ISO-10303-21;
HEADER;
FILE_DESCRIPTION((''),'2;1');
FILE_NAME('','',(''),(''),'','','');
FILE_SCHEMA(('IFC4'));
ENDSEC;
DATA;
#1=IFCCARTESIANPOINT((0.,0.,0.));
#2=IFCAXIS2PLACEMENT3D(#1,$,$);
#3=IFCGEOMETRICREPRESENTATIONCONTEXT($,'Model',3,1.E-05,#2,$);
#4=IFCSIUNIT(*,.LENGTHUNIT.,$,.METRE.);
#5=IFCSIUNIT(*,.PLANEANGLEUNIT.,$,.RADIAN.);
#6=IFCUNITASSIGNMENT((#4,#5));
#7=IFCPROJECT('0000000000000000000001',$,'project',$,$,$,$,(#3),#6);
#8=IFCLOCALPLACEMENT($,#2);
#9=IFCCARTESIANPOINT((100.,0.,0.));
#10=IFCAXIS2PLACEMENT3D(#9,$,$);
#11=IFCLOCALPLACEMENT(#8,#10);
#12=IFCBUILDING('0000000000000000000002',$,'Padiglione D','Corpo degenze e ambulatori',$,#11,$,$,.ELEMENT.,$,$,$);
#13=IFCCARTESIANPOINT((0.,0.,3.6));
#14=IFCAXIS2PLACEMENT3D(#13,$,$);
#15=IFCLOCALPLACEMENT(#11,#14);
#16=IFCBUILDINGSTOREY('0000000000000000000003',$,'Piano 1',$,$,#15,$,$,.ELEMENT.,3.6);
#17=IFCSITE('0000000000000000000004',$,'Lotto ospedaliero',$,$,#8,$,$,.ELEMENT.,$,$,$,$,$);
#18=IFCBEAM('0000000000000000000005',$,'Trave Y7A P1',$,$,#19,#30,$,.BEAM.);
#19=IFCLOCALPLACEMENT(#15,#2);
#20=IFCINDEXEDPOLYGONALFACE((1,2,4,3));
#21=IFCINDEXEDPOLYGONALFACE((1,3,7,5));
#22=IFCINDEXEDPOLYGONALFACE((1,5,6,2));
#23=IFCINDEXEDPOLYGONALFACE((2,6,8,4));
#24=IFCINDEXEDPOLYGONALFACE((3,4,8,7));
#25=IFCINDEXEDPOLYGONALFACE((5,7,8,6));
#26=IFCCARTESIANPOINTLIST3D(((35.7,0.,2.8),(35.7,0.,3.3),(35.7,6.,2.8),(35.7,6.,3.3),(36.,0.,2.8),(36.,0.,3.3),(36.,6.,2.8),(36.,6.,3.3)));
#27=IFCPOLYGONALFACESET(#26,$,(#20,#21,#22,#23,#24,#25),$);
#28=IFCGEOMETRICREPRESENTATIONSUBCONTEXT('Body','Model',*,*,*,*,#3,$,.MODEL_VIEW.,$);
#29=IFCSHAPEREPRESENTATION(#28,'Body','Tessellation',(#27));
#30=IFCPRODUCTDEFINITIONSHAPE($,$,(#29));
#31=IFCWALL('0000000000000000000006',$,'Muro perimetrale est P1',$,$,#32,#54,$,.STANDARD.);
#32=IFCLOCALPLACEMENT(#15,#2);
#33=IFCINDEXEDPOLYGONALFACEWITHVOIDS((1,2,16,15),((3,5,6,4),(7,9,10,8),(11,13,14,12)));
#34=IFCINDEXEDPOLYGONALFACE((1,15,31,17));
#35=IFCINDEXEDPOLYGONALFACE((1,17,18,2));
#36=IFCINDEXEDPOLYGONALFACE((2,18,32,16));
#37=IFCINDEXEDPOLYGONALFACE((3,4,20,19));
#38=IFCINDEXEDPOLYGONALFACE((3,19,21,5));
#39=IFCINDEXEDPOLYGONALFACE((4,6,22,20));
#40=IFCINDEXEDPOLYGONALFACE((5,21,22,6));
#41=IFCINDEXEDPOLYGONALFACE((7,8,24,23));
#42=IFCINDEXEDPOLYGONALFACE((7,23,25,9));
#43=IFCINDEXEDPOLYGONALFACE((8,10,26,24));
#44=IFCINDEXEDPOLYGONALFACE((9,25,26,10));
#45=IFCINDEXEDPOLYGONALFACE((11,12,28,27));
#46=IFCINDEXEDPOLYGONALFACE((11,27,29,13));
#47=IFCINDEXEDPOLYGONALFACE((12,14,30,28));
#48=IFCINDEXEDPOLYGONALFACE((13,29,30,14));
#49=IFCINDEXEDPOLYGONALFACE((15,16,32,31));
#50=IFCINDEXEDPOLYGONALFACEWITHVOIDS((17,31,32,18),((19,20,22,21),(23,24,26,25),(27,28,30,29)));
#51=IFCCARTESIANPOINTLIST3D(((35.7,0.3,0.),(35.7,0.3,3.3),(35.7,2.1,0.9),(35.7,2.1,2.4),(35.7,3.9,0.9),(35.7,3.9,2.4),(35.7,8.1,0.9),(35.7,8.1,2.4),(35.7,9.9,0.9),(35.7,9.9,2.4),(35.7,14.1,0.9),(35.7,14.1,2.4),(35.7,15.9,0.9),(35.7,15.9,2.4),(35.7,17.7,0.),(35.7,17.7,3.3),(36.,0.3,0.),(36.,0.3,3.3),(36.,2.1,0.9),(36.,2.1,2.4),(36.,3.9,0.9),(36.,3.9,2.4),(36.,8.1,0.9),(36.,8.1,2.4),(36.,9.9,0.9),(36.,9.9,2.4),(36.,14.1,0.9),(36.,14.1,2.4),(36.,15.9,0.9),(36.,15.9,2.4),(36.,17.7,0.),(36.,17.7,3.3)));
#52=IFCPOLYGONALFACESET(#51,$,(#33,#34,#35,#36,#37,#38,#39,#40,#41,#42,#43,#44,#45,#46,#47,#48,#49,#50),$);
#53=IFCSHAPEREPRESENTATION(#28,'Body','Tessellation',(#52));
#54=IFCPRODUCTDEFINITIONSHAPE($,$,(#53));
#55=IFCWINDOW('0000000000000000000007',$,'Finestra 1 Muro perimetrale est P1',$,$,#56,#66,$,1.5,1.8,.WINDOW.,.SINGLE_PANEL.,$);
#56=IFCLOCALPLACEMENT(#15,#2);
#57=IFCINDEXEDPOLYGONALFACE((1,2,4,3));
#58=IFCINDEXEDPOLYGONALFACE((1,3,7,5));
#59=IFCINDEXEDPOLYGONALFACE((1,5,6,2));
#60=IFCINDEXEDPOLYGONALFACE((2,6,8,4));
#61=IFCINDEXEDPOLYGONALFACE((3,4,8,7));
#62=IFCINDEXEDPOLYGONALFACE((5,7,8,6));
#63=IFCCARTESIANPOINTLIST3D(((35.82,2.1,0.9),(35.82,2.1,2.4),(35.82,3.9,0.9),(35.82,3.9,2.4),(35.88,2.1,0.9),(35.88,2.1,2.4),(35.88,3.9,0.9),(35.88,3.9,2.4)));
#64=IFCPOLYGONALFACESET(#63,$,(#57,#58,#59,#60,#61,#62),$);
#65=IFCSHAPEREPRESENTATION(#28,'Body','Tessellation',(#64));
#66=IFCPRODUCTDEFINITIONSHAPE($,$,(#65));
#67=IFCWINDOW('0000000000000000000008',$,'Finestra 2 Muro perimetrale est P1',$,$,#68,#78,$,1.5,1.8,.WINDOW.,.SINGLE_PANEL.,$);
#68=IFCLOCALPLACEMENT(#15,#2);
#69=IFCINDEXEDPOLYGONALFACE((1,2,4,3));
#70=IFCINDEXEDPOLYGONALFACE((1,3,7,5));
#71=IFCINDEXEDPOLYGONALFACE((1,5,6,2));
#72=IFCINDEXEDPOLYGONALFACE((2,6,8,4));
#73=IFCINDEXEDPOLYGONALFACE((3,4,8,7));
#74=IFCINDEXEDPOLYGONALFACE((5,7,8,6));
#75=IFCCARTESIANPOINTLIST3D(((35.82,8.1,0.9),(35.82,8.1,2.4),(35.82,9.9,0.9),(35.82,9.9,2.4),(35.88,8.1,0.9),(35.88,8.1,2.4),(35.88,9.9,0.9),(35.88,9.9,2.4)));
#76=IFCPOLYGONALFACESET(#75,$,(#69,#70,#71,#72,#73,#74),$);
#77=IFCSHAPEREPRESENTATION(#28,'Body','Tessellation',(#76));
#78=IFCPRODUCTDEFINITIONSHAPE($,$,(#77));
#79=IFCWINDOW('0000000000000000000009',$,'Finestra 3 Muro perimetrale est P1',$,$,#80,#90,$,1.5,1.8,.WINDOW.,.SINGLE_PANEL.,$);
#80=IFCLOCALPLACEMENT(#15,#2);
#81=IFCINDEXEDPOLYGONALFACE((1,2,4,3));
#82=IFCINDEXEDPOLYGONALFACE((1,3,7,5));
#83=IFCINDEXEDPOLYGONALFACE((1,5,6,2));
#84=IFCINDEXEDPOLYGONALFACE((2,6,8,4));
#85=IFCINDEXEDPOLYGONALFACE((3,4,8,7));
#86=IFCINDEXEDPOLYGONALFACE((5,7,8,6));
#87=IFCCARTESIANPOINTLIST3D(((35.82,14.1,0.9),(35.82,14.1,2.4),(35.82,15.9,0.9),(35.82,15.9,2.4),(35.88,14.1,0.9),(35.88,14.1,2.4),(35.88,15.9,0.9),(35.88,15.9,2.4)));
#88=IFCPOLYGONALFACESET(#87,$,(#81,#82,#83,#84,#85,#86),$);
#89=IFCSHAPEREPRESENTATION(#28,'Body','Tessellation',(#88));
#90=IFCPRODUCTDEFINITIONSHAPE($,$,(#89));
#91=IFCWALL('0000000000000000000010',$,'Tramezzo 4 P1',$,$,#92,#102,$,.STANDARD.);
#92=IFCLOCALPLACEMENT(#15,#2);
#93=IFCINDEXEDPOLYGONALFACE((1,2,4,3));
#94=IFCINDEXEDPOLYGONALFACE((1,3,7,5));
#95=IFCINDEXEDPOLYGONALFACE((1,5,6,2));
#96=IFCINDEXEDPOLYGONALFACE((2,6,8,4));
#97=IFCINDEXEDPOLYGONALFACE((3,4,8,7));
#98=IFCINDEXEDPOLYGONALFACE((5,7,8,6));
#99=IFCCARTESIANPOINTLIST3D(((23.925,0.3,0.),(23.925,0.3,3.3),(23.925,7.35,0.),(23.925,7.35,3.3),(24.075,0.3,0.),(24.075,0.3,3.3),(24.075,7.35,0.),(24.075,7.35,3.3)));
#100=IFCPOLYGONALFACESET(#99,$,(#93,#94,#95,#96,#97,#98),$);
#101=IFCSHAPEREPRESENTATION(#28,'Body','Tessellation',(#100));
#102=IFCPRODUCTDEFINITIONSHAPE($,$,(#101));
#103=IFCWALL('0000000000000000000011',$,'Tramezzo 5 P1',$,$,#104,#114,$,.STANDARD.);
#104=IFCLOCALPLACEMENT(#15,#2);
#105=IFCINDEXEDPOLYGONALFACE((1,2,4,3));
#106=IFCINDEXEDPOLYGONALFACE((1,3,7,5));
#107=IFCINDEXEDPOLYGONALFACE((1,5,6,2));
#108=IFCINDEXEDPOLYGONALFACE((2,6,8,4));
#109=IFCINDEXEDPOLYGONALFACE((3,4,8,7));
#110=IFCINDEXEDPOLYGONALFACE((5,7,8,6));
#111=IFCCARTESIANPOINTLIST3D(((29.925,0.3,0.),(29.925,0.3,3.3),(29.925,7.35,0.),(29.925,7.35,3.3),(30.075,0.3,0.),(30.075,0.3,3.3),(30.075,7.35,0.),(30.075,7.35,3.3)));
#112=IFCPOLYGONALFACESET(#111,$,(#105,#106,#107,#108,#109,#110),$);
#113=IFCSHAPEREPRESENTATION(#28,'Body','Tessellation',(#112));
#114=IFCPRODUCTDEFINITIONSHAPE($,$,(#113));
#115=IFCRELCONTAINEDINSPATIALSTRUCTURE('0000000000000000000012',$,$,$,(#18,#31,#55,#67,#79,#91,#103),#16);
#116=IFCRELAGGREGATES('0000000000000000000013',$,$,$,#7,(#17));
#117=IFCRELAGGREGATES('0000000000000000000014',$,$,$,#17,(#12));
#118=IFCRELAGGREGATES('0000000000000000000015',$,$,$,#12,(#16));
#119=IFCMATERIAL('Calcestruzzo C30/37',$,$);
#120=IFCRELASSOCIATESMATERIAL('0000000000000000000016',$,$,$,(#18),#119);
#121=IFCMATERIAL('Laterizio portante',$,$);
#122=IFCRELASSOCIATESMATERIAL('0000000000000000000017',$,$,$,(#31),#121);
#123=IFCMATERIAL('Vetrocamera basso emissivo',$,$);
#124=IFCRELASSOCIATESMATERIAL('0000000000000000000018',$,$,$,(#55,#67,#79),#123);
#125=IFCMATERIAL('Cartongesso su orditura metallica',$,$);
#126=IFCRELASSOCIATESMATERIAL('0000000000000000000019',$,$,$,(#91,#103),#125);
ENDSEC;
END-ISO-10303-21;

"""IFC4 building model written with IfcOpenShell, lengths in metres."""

from ifc_helpers import new_model, si_unit, frame, frame_2d, origin, place, context, subcontext, project, spatial, rectangle, extrude, material, element, fill, save


model = new_model("IFC4")

# Units and contexts
model_context = context("Model", 3, precision=1e-05, world=origin())
body_context = subcontext(model_context, "Body", "Model", "MODEL_VIEW")
ifc_project = project(units=[si_unit("LENGTHUNIT", "METRE"), si_unit("PLANEANGLEUNIT", "RADIAN")], contexts=[model_context])

# Site, building, storey
site_placement = place(None, origin())
site = spatial("IfcSite", under=ifc_project, at=site_placement, Name="Lotto ospedaliero", CompositionType="ELEMENT")
building_placement = place(site_placement, frame((100.0, 0.0, 0.0)))
building = spatial("IfcBuilding", under=site, at=building_placement, Name="Padiglione D", Description="Corpo degenze e ambulatori", CompositionType="ELEMENT")
storey_placement = place(building_placement, frame((0.0, 0.0, 3.6)))
storey = spatial("IfcBuildingStorey", under=building, at=storey_placement, Name="Piano 1", CompositionType="ELEMENT", Elevation=3.6)

# Shared definitions
ifc_material_1 = material(Name="Calcestruzzo C30/37")

# Beam
for number, where, name in (
    (1, (35.7, 0.0, 2.8), "Trave Y7A P1"),
):
    element("IfcBeam", number, at=place(storey_placement, frame(where)), inside=storey, material=ifc_material_1, Name=name, PredefinedType="BEAM", context=body_context, shape_type="SweptSolid", body=[
        extrude(rectangle(XDim=0.3, YDim=6.0, at=frame_2d((0.15, 3.0))), origin(), (0.0, 0.0, 1.0), 0.5),
    ])

# Wall, openings, windows
ifc_material_2 = material(Name="Laterizio portante")
wall_placement = place(storey_placement, frame((35.7, 0.3, 0.0)))
wall = element("IfcWall", 2, at=wall_placement, inside=storey, material=ifc_material_2, Name="Muro perimetrale est P1", PredefinedType="STANDARD", context=body_context, shape_type="SweptSolid", body=[
    extrude(rectangle(XDim=0.3, YDim=17.4, at=frame_2d((0.15, 8.7))), origin(), (0.0, 0.0, 1.0), 3.3),
])
opening_1_placement = place(wall_placement, frame((-0.1, 1.8, 0.9)))
opening_1 = element("IfcOpeningElement", 3, at=opening_1_placement, cuts=wall, PredefinedType="OPENING", context=body_context, shape_type="SweptSolid", body=[
    extrude(rectangle(XDim=0.5, YDim=1.8, at=frame_2d((0.25, 0.9))), origin(), (0.0, 0.0, 1.0), 1.5),
])
opening_2_placement = place(wall_placement, frame((-0.1, 7.8, 0.9)))
opening_2 = element("IfcOpeningElement", 4, at=opening_2_placement, cuts=wall, PredefinedType="OPENING", context=body_context, shape_type="SweptSolid", body=[
    extrude(rectangle(XDim=0.5, YDim=1.8, at=frame_2d((0.25, 0.9))), origin(), (0.0, 0.0, 1.0), 1.5),
])
opening_3_placement = place(wall_placement, frame((-0.1, 13.8, 0.9)))
opening_3 = element("IfcOpeningElement", 5, at=opening_3_placement, cuts=wall, PredefinedType="OPENING", context=body_context, shape_type="SweptSolid", body=[
    extrude(rectangle(XDim=0.5, YDim=1.8, at=frame_2d((0.25, 0.9))), origin(), (0.0, 0.0, 1.0), 1.5),
])
ifc_material_3 = material(Name="Vetrocamera basso emissivo")
window_1_placement = place(wall_placement, frame((0.12, 1.8, 0.9)))
window_1 = element("IfcWindow", 6, at=window_1_placement, inside=storey, material=ifc_material_3, Name="Finestra 1 Muro perimetrale est P1", OverallHeight=1.5, OverallWidth=1.8, PartitioningType="SINGLE_PANEL", PredefinedType="WINDOW", context=body_context, shape_type="SweptSolid", body=[
    extrude(rectangle(XDim=0.06, YDim=1.8, at=frame_2d((0.03, 0.9))), origin(), (0.0, 0.0, 1.0), 1.5),
])
fill(opening_1, window_1)
window_2_placement = place(wall_placement, frame((0.12, 7.8, 0.9)))
window_2 = element("IfcWindow", 7, at=window_2_placement, inside=storey, material=ifc_material_3, Name="Finestra 2 Muro perimetrale est P1", OverallHeight=1.5, OverallWidth=1.8, PartitioningType="SINGLE_PANEL", PredefinedType="WINDOW", context=body_context, shape_type="SweptSolid", body=[
    extrude(rectangle(XDim=0.06, YDim=1.8, at=frame_2d((0.03, 0.9))), origin(), (0.0, 0.0, 1.0), 1.5),
])
fill(opening_2, window_2)
window_3_placement = place(wall_placement, frame((0.12, 13.8, 0.9)))
window_3 = element("IfcWindow", 8, at=window_3_placement, inside=storey, material=ifc_material_3, Name="Finestra 3 Muro perimetrale est P1", OverallHeight=1.5, OverallWidth=1.8, PartitioningType="SINGLE_PANEL", PredefinedType="WINDOW", context=body_context, shape_type="SweptSolid", body=[
    extrude(rectangle(XDim=0.06, YDim=1.8, at=frame_2d((0.03, 0.9))), origin(), (0.0, 0.0, 1.0), 1.5),
])
fill(opening_3, window_3)

# Walls
ifc_material_4 = material(Name="Cartongesso su orditura metallica")
for number, where, name in (
    (9, (23.925, 0.3, 0.0), "Tramezzo 4 P1"),
    (10, (29.925, 0.3, 0.0), "Tramezzo 5 P1"),
):
    element("IfcWall", number, at=place(storey_placement, frame(where)), inside=storey, material=ifc_material_4, Name=name, PredefinedType="STANDARD", context=body_context, shape_type="SweptSolid", body=[
        extrude(rectangle(XDim=0.15, YDim=7.05, at=frame_2d((0.075, 3.525))), origin(), (0.0, 0.0, 1.0), 3.3),
    ])

save(model, "model.ifc")
